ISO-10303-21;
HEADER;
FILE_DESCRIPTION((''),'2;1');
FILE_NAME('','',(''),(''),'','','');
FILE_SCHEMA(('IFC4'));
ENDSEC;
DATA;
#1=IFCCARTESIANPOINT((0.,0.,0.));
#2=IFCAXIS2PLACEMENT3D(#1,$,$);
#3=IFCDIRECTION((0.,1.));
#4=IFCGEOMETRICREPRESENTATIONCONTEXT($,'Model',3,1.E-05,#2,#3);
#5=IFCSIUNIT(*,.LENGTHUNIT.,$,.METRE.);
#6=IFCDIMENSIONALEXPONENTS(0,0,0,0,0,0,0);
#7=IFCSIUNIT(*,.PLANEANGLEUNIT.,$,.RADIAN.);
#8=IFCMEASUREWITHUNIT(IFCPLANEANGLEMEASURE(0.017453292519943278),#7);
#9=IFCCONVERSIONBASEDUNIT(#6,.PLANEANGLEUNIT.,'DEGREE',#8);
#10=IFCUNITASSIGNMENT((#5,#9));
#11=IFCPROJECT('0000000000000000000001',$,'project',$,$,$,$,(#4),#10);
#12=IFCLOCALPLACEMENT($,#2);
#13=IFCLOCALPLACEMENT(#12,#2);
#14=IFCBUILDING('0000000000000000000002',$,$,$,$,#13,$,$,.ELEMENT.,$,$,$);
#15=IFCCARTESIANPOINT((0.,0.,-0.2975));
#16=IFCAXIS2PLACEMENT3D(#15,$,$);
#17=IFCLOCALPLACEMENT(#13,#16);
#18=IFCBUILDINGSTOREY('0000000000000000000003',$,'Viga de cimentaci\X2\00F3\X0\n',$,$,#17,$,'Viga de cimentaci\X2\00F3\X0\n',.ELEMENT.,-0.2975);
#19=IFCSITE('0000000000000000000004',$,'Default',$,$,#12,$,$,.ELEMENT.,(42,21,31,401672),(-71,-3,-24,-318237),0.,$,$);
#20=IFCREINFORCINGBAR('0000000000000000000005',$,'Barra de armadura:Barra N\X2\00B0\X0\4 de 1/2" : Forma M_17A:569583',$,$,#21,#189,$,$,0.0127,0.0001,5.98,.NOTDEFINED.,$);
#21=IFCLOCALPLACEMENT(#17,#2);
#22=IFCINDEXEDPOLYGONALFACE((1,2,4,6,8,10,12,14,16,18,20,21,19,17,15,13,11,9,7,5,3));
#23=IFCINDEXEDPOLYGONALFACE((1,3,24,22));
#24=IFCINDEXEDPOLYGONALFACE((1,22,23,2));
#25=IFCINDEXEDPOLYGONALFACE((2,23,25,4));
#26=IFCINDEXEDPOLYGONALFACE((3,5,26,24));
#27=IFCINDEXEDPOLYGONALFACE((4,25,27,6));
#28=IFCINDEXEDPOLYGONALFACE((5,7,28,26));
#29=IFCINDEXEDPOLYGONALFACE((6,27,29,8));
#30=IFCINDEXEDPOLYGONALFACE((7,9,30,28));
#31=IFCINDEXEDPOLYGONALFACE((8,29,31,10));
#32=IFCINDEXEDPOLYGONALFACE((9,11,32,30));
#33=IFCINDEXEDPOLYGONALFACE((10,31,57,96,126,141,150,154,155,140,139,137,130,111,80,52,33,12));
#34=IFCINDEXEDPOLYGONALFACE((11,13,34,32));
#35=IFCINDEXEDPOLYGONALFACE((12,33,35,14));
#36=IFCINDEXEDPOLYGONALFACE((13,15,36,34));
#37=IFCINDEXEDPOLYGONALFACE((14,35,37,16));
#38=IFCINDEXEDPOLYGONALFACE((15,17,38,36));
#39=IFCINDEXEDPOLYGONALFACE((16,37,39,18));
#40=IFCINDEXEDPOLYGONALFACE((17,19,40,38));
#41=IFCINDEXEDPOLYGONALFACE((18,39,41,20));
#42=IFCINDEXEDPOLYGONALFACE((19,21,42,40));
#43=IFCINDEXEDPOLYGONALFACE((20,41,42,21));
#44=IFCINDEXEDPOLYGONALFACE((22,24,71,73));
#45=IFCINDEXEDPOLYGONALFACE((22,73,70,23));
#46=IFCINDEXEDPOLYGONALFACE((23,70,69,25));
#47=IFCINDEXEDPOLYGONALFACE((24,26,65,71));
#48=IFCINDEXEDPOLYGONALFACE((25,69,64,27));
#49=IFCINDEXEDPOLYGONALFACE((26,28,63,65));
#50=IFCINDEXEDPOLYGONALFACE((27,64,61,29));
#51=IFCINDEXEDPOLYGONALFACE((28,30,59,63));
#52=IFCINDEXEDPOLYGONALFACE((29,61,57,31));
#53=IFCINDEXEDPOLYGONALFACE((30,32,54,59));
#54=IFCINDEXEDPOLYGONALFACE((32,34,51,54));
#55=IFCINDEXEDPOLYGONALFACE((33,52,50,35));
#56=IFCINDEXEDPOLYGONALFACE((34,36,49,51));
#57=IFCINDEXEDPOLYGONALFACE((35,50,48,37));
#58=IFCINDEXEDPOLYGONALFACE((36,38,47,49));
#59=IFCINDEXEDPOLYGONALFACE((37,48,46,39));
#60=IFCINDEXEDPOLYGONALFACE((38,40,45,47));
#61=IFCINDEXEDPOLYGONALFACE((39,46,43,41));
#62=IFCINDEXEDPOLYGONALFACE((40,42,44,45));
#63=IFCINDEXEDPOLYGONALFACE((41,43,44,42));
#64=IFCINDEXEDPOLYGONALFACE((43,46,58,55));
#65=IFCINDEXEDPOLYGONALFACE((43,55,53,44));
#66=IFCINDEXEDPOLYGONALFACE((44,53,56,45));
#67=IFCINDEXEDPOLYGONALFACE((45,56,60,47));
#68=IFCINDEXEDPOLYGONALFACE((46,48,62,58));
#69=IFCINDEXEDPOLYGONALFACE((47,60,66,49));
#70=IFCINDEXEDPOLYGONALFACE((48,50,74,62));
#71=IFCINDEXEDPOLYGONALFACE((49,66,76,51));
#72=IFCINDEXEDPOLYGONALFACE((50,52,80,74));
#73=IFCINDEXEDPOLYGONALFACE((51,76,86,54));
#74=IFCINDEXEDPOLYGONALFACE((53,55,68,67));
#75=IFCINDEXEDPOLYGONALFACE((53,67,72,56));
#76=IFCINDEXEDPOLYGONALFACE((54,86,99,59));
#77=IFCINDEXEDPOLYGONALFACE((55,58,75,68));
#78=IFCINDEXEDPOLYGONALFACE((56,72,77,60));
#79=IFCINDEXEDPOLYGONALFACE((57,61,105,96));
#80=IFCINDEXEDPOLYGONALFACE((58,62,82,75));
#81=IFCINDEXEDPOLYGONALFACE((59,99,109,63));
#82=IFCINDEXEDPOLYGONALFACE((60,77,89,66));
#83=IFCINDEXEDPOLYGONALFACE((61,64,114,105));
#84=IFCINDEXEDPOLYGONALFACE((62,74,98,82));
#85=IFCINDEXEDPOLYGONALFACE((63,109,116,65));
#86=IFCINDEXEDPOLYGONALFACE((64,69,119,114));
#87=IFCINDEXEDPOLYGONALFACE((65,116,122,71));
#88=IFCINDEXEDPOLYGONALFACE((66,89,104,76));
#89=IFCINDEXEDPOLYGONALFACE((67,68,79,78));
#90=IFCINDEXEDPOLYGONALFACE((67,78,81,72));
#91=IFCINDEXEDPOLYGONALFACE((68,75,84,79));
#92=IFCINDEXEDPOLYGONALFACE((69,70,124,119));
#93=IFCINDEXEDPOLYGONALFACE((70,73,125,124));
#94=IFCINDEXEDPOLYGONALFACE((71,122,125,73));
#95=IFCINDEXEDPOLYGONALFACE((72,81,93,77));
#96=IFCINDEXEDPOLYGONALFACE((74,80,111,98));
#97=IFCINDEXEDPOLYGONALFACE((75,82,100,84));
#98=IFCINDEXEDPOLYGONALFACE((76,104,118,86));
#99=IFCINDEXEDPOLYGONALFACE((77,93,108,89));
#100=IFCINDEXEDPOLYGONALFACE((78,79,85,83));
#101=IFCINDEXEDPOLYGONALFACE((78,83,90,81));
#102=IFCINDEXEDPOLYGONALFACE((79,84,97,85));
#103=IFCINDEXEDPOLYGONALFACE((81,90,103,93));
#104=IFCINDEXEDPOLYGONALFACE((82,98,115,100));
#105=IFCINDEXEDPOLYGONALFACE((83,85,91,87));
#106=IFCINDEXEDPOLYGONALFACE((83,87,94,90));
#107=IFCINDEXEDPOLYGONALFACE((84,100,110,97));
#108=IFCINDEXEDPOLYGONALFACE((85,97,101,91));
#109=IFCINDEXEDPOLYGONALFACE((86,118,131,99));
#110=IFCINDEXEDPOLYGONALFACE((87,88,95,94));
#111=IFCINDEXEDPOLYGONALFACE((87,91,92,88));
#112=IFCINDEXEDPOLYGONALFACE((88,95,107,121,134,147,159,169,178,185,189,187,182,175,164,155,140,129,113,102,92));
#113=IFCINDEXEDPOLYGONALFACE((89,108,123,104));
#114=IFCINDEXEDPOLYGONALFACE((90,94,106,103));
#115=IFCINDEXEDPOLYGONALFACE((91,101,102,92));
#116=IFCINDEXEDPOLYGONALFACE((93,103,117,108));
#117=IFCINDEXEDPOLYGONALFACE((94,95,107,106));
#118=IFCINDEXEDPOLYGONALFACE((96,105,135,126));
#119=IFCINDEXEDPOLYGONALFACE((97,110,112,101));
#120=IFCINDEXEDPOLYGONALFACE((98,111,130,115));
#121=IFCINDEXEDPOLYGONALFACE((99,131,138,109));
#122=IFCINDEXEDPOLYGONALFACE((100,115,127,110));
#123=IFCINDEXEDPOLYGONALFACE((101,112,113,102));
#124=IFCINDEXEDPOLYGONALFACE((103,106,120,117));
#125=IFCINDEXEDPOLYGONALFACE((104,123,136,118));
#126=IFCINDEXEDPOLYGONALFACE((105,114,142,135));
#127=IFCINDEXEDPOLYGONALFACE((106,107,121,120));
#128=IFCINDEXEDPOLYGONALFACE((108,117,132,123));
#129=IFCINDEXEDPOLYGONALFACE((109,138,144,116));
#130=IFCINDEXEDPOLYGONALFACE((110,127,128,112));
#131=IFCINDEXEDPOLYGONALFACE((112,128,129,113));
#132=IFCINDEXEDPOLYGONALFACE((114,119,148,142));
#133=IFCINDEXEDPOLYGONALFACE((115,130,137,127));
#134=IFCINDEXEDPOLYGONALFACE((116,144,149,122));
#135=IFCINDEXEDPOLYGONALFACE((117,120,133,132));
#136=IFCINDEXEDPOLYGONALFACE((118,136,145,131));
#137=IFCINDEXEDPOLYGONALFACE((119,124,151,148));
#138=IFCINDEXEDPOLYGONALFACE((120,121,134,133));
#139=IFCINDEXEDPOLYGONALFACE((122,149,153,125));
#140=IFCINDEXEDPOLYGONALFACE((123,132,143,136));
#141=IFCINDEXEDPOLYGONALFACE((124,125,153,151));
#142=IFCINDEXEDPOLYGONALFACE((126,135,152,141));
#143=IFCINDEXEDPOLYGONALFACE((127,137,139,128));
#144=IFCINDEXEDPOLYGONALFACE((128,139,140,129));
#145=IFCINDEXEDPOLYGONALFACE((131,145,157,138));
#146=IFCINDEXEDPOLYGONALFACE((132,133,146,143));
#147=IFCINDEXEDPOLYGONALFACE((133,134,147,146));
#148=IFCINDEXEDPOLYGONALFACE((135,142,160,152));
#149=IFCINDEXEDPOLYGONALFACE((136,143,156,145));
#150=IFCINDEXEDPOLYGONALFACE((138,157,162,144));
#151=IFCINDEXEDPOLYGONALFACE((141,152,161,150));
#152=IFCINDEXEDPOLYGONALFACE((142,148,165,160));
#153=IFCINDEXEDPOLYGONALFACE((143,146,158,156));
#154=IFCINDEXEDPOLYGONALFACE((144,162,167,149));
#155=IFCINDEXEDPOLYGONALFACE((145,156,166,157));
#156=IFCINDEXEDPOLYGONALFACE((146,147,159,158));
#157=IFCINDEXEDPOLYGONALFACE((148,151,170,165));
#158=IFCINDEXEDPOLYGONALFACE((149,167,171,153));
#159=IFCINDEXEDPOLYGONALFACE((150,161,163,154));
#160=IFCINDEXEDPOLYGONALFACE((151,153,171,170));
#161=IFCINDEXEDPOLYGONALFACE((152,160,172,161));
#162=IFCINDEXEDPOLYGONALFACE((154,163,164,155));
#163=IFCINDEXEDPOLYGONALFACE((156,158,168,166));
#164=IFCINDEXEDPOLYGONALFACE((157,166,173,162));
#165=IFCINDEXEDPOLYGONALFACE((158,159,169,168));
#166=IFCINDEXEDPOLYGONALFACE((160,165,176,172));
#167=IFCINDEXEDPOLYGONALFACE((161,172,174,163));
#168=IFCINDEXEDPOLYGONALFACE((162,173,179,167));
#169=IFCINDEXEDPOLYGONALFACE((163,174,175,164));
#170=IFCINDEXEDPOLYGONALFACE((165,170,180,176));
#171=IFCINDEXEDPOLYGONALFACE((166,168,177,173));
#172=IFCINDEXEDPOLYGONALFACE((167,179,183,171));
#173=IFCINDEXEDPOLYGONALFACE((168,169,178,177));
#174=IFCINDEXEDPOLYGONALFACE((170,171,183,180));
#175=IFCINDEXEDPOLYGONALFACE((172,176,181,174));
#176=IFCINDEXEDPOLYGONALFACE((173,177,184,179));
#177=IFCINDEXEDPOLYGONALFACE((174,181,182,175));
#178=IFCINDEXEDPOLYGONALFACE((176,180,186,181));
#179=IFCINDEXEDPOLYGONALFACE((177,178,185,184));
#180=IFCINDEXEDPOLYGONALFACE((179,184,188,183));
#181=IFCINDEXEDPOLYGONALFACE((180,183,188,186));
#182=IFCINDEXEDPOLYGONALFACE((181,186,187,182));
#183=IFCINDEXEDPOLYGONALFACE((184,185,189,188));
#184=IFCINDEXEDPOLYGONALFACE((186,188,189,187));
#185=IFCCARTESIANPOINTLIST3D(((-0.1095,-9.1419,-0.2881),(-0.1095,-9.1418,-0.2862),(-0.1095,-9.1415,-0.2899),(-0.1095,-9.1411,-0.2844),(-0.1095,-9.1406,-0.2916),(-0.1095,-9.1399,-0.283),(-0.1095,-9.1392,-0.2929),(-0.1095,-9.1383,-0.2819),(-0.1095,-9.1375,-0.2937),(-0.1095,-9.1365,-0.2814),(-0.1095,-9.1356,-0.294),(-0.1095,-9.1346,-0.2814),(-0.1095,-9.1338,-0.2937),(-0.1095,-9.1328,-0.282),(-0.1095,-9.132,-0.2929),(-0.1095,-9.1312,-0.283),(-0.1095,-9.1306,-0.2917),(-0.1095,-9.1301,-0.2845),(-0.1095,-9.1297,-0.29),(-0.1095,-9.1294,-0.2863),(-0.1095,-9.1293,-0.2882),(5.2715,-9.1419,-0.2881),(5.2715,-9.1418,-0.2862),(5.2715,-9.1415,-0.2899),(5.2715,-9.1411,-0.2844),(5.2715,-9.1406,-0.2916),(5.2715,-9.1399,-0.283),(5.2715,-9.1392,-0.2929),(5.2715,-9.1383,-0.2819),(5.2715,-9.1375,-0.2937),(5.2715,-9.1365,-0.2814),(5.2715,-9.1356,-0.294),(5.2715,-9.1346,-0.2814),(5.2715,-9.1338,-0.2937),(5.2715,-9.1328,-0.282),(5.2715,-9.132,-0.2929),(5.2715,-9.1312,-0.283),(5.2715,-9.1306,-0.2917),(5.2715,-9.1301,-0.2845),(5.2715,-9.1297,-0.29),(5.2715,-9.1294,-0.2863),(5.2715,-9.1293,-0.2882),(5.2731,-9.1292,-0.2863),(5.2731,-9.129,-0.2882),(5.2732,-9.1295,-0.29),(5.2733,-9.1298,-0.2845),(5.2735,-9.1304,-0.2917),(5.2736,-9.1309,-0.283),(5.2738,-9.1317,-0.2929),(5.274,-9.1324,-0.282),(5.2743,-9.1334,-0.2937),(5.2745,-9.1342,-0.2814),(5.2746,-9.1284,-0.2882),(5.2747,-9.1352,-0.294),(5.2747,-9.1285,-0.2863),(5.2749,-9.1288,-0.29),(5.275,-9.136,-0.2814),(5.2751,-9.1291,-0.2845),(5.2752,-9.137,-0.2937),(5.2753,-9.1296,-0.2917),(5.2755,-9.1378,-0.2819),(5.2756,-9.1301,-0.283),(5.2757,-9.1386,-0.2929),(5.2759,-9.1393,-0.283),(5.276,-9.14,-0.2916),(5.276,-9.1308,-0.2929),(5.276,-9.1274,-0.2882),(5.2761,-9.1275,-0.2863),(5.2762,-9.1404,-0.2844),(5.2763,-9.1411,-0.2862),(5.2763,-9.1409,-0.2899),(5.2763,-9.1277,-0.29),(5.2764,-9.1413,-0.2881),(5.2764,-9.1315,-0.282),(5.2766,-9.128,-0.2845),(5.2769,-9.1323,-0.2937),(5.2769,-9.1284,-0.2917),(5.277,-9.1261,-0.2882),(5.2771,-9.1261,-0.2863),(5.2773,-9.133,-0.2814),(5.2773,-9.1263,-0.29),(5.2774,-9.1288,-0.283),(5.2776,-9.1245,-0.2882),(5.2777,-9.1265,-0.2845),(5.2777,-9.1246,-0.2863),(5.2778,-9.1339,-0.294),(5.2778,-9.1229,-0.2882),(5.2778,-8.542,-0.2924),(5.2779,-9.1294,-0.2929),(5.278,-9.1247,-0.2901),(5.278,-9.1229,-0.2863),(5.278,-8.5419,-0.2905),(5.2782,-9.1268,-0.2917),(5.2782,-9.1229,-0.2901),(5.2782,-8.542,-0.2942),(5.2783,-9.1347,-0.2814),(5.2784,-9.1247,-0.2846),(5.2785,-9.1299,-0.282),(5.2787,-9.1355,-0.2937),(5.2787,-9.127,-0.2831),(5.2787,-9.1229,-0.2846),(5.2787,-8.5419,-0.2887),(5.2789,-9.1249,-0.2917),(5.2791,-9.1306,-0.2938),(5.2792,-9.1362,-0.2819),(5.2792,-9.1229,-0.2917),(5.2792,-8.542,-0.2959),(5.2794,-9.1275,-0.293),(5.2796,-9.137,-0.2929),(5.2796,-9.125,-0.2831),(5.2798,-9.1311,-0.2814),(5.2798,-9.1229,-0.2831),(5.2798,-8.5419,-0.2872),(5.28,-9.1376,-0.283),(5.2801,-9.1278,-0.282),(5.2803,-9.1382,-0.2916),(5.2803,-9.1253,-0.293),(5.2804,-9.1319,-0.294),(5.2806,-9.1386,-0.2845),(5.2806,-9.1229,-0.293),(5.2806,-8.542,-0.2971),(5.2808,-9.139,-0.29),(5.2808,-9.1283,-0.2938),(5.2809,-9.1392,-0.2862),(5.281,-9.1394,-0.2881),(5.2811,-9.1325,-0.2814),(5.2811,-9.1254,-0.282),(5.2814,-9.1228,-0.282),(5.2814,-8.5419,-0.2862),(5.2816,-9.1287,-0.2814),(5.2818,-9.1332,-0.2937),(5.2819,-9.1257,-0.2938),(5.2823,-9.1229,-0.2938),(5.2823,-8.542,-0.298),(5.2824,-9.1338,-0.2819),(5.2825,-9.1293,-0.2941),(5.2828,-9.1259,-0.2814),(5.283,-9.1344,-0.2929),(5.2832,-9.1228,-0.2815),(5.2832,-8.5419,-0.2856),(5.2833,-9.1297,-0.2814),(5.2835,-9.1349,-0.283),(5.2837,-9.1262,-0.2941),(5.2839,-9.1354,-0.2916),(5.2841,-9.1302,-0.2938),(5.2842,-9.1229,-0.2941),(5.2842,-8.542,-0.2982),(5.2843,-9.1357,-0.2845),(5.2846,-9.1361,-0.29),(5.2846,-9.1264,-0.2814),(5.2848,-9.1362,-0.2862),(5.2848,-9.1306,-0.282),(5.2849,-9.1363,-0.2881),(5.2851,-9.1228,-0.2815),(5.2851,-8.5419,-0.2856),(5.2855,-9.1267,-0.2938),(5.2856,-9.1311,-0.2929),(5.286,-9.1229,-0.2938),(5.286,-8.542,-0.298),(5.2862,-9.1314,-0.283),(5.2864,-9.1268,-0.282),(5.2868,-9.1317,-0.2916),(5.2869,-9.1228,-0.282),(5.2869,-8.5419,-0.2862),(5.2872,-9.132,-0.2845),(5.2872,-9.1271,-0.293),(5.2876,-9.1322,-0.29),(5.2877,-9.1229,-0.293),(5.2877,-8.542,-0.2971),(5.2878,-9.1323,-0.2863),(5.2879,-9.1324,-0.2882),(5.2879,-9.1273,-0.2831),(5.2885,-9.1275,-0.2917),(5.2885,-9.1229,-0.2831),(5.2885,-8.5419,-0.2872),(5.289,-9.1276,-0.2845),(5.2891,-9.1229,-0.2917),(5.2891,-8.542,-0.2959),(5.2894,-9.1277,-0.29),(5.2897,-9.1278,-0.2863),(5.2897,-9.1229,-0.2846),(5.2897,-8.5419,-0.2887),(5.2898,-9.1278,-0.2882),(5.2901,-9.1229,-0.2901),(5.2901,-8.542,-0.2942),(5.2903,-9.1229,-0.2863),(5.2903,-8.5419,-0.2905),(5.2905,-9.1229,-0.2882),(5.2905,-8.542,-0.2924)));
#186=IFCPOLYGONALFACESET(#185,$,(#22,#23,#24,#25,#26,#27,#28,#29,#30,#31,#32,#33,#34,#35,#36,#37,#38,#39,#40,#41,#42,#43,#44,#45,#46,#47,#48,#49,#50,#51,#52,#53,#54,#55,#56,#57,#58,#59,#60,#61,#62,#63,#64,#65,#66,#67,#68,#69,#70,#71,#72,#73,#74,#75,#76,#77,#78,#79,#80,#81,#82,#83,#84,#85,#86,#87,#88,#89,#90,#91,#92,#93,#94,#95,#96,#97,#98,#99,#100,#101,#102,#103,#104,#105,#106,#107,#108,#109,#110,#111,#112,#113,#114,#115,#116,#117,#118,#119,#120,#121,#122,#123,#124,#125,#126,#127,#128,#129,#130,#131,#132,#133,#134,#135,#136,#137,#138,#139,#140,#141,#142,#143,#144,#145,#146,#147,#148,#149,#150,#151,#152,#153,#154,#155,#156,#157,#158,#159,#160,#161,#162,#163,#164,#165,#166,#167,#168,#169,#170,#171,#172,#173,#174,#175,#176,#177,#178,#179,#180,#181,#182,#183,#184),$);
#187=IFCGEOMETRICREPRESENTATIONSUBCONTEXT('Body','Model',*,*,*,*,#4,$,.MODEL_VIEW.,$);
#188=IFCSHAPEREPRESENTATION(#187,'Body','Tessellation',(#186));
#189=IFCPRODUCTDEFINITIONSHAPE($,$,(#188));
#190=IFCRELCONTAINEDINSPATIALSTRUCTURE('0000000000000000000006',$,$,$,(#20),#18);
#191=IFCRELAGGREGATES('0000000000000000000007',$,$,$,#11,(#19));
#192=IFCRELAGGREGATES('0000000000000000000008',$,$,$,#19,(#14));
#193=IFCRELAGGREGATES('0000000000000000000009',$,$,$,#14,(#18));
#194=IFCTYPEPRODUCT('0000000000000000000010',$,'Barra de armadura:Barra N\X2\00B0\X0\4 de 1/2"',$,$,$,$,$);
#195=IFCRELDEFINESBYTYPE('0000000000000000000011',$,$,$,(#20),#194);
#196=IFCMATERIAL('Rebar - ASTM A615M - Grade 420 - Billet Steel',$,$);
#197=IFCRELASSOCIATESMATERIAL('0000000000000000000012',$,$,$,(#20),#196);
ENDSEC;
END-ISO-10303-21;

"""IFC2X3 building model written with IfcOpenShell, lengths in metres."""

from ifc_helpers import new_model, entity, si_unit, converted_unit, direction, frame, origin, place, context, subcontext, project, spatial, material, type_object, element, save


model = new_model("IFC2X3")

# Units and contexts
model_context = context("Model", 3, precision=1e-05, world=origin(), true_north=direction((0.0, 1.0)))
body_context = subcontext(model_context, "Body", "Model", "MODEL_VIEW")
ifc_project = project(units=[si_unit("LENGTHUNIT", "METRE"), converted_unit("PLANEANGLEUNIT", "DEGREE", entity("IfcPlaneAngleMeasure", 0.017453292519943278), si_unit("PLANEANGLEUNIT", "RADIAN"), dimensions=[0, 0, 0, 0, 0, 0, 0])], contexts=[model_context])

# Site, building, storey
site_placement = place(None, origin())
site = spatial("IfcSite", under=ifc_project, at=site_placement, Name="Default", CompositionType="ELEMENT", RefLatitude=(42, 21, 31, 401672), RefLongitude=(-71, -3, -24, -318237), RefElevation=0.0)
building_placement = place(site_placement, origin())
building = spatial("IfcBuilding", under=site, at=building_placement, CompositionType="ELEMENT")
storey_placement = place(building_placement, frame((0.0, 0.0, -0.2975)))
storey = spatial("IfcBuildingStorey", under=building, at=storey_placement, Name="Viga de cimentación", LongName="Viga de cimentación", CompositionType="ELEMENT", Elevation=-0.2975)

# Reinforcing bar
ifc_material = material(Name="Rebar - ASTM A615M - Grade 420 - Billet Steel")
type_product_1 = type_object("IfcTypeProduct", Name="Barra de armadura:Barra N°4 de 1/2\"")
reinforcing_bar_1_placement = place(storey_placement, origin())
element("IfcReinforcingBar", 1, at=reinforcing_bar_1_placement, inside=storey, type_object=type_product_1, material=ifc_material, Name="Barra de armadura:Barra N°4 de 1/2\" : Forma M_17A:569583", BarLength=5.98, BarRole="NOTDEFINED", CrossSectionArea=0.0001, NominalDiameter=0.0127, context=body_context, shape_type="AdvancedSweptSolid", body=[
    entity("IfcSweptDiskSolid", entity("IfcCompositeCurve", [entity("IfcCompositeCurveSegment", "CONTINUOUS", True, entity("IfcPolyline", [entity("IfcCartesianPoint", [5.2842, -8.5419, -0.2919]), entity("IfcCartesianPoint", [5.2842, -9.1229, -0.2877])])), entity("IfcCompositeCurveSegment", "CONTINUOUS", True, entity("IfcTrimmedCurve", entity("IfcCircle", entity("IfcAxis2Placement3D", entity("IfcCartesianPoint", [5.2715, -9.1229, -0.2877]), entity("IfcDirection", [0.0, -0.007141, -0.999975]), entity("IfcDirection", [0.0, -0.999975, 0.007141])), 0.0127), [entity("IfcParameterValue", 270.0)], [entity("IfcParameterValue", 360.0)], True, "PARAMETER")), entity("IfcCompositeCurveSegment", "CONTINUOUS", True, entity("IfcPolyline", [entity("IfcCartesianPoint", [5.2715, -9.1356, -0.2877]), entity("IfcCartesianPoint", [-0.1095, -9.1356, -0.2877])]))], False), 0.0063, None, 0.0, 92.0),
])

save(model, "model.ifc")
